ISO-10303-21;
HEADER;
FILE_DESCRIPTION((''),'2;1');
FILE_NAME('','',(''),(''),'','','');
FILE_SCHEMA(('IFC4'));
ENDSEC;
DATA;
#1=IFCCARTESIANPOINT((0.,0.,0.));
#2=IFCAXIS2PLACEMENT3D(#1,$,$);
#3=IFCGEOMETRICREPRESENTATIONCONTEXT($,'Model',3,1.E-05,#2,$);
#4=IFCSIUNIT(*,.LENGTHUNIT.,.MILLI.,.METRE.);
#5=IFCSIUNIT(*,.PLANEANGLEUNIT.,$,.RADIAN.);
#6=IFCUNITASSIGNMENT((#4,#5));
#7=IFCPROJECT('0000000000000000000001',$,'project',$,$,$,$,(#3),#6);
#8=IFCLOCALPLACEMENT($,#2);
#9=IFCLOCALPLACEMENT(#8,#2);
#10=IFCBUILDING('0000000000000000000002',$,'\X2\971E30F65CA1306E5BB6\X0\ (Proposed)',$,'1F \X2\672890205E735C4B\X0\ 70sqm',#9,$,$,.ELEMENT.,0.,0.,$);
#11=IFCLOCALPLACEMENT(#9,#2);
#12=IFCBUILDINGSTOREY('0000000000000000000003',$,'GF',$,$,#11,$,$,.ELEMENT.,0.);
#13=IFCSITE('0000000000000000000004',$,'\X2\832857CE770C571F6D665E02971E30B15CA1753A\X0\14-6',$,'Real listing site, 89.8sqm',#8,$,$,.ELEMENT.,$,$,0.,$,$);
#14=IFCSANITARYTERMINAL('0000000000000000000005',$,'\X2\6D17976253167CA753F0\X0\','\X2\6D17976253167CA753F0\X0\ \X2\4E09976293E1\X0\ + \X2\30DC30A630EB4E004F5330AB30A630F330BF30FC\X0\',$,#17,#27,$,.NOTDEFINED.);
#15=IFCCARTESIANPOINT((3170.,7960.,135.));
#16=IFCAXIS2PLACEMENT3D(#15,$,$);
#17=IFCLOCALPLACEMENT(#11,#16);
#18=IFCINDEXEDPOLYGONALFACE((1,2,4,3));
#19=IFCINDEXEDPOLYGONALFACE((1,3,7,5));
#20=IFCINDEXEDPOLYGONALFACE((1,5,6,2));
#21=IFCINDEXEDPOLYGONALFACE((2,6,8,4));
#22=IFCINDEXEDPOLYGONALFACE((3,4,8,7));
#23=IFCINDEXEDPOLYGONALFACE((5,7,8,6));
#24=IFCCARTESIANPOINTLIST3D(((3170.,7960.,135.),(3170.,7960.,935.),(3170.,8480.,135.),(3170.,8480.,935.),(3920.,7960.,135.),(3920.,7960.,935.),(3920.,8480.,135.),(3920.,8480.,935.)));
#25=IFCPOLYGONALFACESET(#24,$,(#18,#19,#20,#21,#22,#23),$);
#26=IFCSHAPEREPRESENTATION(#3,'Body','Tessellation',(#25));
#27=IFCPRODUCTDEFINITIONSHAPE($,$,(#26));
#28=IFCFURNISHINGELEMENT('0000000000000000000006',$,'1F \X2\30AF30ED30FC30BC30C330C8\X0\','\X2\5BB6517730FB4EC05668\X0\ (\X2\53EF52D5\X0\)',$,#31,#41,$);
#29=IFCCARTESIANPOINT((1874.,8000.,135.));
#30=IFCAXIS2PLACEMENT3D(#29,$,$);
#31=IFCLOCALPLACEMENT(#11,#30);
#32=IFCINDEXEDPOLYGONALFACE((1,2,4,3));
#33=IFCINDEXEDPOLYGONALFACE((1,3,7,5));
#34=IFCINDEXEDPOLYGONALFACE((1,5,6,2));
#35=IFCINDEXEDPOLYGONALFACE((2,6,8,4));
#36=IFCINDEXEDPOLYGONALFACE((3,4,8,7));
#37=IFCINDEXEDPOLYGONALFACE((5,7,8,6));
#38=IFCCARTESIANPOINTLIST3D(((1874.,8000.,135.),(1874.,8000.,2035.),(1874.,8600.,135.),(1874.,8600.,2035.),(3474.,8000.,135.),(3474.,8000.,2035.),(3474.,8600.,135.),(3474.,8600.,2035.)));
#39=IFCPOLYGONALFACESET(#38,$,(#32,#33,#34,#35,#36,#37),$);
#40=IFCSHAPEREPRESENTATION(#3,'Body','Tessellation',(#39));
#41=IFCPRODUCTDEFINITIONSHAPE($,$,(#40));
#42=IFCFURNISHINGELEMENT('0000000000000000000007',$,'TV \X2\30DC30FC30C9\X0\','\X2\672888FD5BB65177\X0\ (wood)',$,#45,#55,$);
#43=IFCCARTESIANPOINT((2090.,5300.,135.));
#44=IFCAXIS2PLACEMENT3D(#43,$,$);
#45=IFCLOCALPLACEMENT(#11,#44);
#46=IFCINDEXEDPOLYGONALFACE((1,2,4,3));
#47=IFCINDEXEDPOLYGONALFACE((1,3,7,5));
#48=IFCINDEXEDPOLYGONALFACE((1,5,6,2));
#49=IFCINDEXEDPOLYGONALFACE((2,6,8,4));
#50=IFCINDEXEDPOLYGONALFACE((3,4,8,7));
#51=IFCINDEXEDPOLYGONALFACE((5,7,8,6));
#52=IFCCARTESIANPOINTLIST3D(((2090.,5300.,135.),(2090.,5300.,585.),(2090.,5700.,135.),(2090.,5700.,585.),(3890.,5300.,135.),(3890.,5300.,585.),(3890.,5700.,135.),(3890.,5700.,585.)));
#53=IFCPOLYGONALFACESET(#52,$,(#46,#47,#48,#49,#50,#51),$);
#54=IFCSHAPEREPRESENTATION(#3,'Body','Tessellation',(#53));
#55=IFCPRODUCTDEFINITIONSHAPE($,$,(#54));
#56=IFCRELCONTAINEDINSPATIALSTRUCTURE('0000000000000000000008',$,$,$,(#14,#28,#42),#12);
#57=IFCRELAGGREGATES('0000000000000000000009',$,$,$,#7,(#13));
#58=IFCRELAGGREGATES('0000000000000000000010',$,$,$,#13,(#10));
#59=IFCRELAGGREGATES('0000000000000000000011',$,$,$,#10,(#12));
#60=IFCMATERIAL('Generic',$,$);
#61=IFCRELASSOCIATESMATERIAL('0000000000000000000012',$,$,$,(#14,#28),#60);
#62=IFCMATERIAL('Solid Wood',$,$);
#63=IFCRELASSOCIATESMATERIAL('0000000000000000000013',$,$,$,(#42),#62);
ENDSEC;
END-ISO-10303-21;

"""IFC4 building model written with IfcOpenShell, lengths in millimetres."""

from ifc_helpers import new_model, si_unit, frame, frame_2d, origin, place, context, project, spatial, rectangle, extrude, material, element, save


model = new_model("IFC4")

# Units and contexts
model_context = context("Model", 3, precision=1e-05, world=origin())
ifc_project = project(units=[si_unit("LENGTHUNIT", "METRE", prefix="MILLI"), si_unit("PLANEANGLEUNIT", "RADIAN")], contexts=[model_context])

# Site, building, storey
site_placement = place(None, origin())
site = spatial("IfcSite", under=ifc_project, at=site_placement, Name="茨城県土浦市霞ケ岡町14-6", ObjectType="Real listing site, 89.8sqm", CompositionType="ELEMENT", RefElevation=0.0)
building_placement = place(site_placement, origin())
building = spatial("IfcBuilding", under=site, at=building_placement, Name="霞ヶ岡の家 (Proposed)", ObjectType="1F 木造平屋 70sqm", CompositionType="ELEMENT", ElevationOfRefHeight=0.0, ElevationOfTerrain=0.0)
storey_placement = place(building_placement, origin())
storey = spatial("IfcBuildingStorey", under=building, at=storey_placement, Name="GF", CompositionType="ELEMENT", Elevation=0.0)

# Shared definitions
ifc_material_1 = material(Name="Solid Wood")

# Shared definitions
ifc_material_2 = material(Name="Generic")

# Sanitary terminal
sanitary_terminal_1_placement = place(storey_placement, frame((3170.0, 7960.0, 135.0)))
element("IfcSanitaryTerminal", 1, at=sanitary_terminal_1_placement, inside=storey, material=ifc_material_2, Name="洗面化粧台", Description="洗面化粧台 三面鏡 + ボウル一体カウンター", PredefinedType="NOTDEFINED", context=model_context, shape_type="SweptSolid", body=[
    extrude(rectangle(XDim=750.0, YDim=520.0, at=frame_2d((375.0, 260.0))), frame((3170.0, 7960.0, 135.0)), (0.0, 0.0, 1.0), 800.0),
])

# Furnishing elements
furnishing_1_placement = place(storey_placement, frame((1874.0, 8000.0, 135.0)))
element("IfcFurnishingElement", 2, at=furnishing_1_placement, inside=storey, material=ifc_material_2, Name="1F クローゼット", Description="家具・什器 (可動)", context=model_context, shape_type="SweptSolid", body=[
    extrude(rectangle(XDim=1600.0, YDim=600.0, at=frame_2d((800.0, 300.0))), frame((1874.0, 8000.0, 135.0)), (0.0, 0.0, 1.0), 1900.0),
])
furnishing_2_placement = place(storey_placement, frame((2090.0, 5300.0, 135.0)))
element("IfcFurnishingElement", 3, at=furnishing_2_placement, inside=storey, material=ifc_material_1, Name="TV ボード", Description="木製家具 (wood)", context=model_context, shape_type="SweptSolid", body=[
    extrude(rectangle(XDim=1800.0, YDim=400.0, at=frame_2d((900.0, 200.0))), frame((2090.0, 5300.0, 135.0)), (0.0, 0.0, 1.0), 450.0),
])

save(model, "model.ifc")
